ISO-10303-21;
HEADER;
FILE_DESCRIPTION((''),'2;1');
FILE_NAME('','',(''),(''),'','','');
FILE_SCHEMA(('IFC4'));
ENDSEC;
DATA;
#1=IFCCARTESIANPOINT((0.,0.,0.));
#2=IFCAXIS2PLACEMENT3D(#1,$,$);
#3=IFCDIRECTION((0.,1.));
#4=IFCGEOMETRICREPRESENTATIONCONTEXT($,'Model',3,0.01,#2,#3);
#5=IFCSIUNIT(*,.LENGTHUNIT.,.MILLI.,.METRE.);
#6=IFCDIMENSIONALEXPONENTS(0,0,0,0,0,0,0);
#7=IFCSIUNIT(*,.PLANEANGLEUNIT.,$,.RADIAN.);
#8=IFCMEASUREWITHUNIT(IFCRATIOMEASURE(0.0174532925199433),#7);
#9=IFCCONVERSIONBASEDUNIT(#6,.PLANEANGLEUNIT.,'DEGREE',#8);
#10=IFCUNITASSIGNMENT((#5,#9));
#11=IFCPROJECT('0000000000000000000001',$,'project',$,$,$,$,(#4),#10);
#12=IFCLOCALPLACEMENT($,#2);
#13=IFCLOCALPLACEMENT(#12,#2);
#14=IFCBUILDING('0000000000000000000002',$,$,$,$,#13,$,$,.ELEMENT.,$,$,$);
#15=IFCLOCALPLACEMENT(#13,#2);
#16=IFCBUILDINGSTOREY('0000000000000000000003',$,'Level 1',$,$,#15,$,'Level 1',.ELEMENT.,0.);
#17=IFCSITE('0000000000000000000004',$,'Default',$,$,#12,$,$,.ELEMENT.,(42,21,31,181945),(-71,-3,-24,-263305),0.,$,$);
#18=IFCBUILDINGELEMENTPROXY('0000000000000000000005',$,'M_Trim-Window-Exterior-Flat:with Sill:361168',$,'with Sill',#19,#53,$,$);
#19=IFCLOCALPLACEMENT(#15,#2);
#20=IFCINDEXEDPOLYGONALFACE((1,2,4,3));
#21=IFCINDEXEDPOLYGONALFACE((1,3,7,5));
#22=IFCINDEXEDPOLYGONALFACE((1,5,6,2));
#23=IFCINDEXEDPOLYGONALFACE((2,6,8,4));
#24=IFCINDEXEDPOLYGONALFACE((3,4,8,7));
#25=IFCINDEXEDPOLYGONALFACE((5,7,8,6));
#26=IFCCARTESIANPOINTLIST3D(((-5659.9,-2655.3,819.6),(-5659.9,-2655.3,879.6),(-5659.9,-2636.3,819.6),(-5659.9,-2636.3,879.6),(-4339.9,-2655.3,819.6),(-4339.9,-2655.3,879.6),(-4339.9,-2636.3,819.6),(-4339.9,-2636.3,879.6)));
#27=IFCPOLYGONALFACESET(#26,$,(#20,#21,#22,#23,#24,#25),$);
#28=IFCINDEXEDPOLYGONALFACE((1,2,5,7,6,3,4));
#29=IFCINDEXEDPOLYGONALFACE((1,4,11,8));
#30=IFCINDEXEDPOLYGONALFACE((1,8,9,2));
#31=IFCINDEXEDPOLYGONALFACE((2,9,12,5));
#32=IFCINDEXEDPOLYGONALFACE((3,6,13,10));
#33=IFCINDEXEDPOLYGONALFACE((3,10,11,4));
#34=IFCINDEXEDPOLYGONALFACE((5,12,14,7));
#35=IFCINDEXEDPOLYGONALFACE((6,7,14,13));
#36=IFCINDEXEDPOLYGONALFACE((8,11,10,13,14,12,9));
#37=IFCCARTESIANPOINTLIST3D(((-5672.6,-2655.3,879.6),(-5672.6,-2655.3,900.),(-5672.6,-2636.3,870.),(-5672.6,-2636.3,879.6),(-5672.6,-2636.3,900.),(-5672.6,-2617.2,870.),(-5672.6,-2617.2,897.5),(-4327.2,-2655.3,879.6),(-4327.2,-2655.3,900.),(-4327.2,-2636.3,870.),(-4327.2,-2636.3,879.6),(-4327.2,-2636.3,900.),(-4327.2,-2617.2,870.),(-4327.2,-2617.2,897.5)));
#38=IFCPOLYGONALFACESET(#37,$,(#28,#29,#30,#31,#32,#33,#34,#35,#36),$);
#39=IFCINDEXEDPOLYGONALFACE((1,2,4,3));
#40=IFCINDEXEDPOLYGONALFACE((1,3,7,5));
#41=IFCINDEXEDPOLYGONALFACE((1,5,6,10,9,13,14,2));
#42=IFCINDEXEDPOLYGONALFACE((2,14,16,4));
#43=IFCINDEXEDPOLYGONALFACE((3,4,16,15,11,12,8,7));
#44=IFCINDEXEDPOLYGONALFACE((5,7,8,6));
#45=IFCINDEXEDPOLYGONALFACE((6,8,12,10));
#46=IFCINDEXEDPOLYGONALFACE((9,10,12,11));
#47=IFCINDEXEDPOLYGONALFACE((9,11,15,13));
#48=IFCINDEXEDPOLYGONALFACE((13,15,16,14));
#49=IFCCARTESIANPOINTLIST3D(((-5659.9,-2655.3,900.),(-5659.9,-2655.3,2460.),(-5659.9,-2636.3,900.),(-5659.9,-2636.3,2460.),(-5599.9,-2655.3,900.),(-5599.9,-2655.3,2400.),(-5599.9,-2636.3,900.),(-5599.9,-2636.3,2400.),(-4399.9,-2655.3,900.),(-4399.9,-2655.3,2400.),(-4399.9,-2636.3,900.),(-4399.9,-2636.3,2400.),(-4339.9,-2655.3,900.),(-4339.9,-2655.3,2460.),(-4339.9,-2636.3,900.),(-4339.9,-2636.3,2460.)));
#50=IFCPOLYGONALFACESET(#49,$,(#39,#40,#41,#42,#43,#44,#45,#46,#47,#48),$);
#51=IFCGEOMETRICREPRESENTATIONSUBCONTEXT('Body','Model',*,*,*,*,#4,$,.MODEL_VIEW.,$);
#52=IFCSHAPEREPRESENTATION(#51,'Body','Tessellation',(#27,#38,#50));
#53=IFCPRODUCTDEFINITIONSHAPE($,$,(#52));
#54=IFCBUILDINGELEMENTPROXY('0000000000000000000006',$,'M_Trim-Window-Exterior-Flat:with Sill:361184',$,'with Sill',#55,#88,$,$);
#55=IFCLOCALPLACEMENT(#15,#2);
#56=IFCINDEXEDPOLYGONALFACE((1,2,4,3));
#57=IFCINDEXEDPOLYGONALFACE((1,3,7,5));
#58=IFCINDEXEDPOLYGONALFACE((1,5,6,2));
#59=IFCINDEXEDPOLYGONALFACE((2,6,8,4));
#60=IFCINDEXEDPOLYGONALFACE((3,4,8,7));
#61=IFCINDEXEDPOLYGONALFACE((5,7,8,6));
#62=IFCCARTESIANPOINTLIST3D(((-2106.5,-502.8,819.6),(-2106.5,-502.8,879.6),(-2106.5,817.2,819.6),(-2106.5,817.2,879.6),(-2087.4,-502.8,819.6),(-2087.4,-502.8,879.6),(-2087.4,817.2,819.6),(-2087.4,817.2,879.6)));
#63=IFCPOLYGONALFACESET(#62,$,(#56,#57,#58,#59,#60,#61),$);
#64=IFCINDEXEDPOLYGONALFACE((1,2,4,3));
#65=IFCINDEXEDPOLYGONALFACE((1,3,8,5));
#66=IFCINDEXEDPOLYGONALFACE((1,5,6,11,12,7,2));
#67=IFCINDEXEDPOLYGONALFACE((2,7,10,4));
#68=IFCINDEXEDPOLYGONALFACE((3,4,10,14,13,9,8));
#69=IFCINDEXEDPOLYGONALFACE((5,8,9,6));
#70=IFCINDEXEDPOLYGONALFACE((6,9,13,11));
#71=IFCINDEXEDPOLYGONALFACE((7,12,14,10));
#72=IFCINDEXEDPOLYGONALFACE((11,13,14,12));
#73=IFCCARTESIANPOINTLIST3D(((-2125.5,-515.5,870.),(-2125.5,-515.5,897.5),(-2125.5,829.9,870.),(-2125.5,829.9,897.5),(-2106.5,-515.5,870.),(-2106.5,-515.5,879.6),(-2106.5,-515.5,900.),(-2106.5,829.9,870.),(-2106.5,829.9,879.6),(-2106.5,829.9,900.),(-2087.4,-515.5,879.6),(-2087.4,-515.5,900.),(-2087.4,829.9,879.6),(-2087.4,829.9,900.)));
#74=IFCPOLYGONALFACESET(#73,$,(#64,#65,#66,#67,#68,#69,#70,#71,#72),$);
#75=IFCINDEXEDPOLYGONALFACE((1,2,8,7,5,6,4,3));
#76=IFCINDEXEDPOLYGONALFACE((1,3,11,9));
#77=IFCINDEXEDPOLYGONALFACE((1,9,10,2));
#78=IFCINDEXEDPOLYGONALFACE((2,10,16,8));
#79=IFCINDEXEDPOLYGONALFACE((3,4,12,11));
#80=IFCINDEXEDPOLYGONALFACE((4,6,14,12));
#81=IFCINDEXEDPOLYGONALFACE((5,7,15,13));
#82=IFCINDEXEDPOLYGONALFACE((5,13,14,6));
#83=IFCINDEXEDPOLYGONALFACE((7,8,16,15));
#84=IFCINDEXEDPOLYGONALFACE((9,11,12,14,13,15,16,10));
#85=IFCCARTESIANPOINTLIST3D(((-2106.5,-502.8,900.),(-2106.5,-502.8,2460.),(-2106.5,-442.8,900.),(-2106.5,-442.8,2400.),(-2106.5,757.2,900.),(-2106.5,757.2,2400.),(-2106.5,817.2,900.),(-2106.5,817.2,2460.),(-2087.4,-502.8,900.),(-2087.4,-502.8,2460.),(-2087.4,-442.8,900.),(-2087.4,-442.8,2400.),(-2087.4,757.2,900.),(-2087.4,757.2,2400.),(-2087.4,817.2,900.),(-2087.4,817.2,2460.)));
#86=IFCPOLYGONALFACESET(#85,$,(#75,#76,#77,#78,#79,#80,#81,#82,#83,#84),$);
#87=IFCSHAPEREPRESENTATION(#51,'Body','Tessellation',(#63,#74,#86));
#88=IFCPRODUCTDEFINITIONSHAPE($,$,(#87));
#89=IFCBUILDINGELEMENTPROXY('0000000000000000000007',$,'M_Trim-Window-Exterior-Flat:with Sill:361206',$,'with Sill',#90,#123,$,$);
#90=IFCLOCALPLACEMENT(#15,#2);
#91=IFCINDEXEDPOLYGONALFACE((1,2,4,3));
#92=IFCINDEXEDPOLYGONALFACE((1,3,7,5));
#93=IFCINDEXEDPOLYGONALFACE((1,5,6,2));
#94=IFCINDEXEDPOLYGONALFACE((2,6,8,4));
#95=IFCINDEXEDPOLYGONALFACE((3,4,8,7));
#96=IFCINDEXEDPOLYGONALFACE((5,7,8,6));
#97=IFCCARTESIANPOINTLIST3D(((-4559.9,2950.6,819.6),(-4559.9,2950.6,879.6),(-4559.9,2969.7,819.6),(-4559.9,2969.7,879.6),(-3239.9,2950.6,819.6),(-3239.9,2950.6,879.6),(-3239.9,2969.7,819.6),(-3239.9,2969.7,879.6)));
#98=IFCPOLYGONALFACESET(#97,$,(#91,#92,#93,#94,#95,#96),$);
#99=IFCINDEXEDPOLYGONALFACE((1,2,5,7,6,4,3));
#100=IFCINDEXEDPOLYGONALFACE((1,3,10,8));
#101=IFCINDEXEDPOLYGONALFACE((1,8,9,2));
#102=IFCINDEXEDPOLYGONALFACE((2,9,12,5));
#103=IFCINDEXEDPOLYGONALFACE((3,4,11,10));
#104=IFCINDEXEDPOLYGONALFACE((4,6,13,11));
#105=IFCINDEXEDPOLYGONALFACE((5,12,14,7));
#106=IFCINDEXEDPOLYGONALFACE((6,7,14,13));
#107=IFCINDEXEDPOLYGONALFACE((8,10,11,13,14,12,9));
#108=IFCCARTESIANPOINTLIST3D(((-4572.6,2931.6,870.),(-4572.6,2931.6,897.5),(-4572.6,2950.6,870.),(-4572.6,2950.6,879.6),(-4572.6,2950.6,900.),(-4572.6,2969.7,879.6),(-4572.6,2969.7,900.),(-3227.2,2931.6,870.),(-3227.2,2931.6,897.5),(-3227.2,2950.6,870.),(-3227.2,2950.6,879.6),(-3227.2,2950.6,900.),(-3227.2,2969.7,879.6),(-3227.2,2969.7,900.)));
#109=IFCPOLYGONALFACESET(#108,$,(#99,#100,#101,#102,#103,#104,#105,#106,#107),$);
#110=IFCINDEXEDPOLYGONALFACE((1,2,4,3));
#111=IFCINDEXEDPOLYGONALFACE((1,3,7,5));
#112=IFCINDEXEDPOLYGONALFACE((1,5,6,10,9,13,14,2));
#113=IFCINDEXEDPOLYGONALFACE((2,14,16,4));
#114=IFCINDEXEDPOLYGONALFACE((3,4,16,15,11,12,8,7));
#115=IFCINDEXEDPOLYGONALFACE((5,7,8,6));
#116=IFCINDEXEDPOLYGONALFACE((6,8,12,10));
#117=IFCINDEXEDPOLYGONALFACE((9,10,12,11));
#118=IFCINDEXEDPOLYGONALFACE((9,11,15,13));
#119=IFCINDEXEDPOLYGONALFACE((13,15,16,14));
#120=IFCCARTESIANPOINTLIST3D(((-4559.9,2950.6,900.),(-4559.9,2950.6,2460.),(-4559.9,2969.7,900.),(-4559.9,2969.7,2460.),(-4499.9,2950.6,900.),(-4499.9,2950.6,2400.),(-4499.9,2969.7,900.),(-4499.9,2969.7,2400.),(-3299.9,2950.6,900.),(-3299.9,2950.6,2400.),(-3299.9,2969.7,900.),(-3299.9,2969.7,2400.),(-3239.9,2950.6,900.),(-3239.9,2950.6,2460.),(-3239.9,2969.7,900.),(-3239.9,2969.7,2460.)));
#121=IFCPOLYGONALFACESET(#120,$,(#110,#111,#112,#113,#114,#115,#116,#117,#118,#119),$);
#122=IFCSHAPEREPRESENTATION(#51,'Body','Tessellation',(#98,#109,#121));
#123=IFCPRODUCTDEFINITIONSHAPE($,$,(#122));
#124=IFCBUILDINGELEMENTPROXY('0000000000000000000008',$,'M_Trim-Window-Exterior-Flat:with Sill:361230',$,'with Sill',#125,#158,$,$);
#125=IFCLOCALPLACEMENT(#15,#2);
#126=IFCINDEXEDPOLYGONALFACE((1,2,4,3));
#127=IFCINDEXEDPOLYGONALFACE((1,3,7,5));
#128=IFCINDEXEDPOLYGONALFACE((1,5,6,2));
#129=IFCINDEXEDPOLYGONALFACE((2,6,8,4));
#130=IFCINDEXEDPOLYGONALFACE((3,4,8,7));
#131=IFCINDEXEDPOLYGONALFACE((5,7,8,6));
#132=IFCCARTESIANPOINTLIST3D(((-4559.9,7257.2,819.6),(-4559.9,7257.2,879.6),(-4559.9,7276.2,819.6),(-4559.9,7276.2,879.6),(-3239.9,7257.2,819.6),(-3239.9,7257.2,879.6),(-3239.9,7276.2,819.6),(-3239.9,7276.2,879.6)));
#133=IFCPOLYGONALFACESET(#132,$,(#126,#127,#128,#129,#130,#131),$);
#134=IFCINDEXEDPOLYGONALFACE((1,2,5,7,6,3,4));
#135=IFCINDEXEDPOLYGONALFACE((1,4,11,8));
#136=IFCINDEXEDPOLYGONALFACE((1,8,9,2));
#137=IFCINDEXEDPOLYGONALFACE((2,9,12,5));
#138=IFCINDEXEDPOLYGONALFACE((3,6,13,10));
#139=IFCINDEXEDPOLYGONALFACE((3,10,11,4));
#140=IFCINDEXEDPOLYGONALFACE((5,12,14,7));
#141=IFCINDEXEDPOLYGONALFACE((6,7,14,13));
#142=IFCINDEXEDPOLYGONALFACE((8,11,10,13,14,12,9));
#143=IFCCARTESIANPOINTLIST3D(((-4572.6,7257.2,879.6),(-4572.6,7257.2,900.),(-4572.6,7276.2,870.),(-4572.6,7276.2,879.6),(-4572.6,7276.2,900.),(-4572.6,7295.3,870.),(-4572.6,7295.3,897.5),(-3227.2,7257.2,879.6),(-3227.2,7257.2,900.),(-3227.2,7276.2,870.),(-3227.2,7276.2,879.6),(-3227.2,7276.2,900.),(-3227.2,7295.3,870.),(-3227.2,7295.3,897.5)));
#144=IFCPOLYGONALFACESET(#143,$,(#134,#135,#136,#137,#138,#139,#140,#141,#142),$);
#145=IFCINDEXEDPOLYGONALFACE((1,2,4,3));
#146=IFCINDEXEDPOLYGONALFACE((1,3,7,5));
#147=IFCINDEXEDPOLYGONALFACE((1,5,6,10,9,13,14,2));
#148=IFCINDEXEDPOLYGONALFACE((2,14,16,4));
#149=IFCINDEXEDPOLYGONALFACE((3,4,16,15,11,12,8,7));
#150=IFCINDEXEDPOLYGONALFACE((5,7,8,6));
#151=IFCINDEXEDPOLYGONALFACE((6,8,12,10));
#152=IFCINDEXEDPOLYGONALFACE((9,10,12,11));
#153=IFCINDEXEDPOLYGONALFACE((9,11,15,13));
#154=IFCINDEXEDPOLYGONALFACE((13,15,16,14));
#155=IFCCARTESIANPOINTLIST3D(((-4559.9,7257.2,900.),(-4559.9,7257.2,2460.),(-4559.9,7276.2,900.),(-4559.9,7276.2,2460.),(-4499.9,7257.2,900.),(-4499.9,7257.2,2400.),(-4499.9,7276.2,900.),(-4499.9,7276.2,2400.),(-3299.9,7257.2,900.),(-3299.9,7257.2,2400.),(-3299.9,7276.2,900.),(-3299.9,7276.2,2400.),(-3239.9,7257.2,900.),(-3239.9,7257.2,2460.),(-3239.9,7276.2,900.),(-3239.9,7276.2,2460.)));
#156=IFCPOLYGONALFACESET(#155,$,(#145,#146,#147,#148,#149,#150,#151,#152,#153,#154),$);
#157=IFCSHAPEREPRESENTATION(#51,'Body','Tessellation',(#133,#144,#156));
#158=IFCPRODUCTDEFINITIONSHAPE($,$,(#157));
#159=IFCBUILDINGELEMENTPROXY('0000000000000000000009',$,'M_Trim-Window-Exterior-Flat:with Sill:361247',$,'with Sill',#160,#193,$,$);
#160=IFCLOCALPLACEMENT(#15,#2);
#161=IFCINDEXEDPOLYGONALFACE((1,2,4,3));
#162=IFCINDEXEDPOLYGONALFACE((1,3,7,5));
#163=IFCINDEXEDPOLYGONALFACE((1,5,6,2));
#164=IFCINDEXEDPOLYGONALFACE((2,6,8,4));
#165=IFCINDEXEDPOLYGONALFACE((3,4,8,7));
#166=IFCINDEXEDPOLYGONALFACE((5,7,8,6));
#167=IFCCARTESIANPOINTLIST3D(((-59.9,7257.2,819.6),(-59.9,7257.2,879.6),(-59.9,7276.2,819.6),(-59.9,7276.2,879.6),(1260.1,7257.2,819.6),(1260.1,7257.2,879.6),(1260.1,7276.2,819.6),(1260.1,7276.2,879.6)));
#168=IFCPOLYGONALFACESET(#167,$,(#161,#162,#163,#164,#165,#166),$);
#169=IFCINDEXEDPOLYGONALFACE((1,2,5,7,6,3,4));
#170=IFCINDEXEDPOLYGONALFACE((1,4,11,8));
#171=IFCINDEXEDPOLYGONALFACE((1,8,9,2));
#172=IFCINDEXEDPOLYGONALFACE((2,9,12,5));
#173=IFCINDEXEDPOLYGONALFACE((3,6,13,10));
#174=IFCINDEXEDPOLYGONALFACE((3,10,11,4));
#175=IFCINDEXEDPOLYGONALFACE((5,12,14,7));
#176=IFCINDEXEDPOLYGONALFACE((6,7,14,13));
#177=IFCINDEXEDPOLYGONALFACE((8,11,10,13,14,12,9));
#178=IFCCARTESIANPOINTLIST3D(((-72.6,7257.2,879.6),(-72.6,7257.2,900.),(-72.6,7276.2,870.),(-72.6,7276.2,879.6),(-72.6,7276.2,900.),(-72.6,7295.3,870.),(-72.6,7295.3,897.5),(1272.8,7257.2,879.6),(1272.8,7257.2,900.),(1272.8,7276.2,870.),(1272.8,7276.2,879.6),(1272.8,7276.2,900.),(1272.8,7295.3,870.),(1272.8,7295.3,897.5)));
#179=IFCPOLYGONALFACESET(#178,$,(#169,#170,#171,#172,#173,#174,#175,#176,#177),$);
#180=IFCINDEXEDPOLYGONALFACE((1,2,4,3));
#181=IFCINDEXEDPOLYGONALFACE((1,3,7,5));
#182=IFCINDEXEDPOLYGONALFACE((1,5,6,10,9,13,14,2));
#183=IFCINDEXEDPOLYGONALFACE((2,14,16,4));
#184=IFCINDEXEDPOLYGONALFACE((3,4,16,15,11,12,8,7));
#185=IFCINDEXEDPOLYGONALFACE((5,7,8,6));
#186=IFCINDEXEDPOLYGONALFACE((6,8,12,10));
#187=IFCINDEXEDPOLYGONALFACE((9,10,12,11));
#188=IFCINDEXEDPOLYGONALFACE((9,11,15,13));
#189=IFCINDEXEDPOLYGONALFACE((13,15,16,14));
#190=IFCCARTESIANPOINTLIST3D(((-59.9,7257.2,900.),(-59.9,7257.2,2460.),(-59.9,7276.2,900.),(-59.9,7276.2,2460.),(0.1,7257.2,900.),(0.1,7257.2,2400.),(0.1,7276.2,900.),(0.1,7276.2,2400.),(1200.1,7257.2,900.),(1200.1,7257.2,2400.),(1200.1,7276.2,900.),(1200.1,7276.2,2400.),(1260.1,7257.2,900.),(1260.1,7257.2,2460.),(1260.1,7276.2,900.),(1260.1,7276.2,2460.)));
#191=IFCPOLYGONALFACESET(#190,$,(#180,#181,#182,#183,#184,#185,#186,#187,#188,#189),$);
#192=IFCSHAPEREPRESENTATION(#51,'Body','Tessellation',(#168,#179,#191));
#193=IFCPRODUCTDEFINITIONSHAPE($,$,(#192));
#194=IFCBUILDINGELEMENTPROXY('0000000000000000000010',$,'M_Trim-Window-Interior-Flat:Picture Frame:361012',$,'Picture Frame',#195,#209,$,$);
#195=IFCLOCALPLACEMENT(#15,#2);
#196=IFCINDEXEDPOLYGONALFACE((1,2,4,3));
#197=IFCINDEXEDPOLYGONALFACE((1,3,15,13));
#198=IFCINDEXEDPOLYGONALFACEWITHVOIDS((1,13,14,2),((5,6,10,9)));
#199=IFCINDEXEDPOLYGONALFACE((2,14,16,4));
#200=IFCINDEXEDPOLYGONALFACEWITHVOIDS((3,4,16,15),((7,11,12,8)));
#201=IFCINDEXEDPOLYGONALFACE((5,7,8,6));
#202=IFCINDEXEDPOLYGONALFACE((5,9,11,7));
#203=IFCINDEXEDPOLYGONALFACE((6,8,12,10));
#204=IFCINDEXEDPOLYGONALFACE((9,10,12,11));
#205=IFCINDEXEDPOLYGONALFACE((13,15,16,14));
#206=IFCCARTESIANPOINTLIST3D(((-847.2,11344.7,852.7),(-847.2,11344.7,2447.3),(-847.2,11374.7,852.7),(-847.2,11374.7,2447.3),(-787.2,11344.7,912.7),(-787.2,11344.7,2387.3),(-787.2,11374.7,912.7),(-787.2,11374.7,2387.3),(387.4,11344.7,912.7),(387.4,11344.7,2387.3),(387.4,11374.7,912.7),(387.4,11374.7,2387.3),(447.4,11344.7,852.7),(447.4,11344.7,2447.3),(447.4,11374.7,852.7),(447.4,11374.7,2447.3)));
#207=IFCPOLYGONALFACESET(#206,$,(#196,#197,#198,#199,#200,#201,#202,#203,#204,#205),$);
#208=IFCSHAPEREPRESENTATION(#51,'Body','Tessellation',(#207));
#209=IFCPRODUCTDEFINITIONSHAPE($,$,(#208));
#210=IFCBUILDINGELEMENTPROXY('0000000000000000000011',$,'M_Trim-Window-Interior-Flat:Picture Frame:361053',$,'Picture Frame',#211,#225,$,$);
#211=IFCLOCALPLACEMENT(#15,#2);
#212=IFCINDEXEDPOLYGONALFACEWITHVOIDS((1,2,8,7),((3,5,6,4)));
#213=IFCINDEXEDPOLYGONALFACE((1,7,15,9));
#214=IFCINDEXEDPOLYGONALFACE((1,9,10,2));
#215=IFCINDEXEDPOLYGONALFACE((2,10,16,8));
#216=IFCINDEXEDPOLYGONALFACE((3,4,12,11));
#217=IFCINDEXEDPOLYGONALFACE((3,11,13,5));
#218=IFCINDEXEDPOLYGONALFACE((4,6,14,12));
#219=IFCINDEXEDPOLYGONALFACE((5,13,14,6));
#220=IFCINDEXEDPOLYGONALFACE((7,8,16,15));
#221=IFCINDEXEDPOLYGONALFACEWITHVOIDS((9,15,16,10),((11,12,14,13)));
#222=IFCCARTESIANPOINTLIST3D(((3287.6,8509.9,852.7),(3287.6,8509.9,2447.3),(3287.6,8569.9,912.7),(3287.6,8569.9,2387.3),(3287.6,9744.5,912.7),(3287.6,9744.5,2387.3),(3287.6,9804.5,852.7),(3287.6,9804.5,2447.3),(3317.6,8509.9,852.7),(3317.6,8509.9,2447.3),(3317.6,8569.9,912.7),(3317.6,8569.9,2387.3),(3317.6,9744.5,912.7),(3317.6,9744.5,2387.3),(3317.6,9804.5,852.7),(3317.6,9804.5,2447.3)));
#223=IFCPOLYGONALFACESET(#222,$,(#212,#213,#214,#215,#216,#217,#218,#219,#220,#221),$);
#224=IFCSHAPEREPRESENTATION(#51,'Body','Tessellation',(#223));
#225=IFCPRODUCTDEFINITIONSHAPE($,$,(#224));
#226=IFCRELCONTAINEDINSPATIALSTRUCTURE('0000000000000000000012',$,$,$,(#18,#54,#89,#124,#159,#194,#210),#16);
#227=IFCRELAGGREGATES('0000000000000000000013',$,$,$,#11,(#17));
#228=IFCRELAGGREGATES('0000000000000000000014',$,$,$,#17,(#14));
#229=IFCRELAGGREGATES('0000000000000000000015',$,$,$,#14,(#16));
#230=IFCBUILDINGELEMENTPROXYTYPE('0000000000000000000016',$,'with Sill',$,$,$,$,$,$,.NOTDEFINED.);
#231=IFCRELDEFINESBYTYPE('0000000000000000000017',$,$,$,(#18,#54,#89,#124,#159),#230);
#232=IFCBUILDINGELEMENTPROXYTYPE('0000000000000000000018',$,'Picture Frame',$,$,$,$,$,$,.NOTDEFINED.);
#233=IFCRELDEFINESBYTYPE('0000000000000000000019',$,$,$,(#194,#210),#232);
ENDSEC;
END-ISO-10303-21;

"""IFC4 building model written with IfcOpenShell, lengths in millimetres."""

from ifc_helpers import new_model, entity, si_unit, converted_unit, direction, frame, frame_2d, origin, place, context, subcontext, project, spatial, polyline, rectangle, outline, extrude, source, transform, mapped, type_object, type_shapes, element, save


model = new_model("IFC4")

# Units and contexts
model_context = context("Model", 3, precision=0.01, world=origin(), true_north=direction((0.0, 1.0)))
body_context = subcontext(model_context, "Body", "Model", "MODEL_VIEW")
ifc_project = project(units=[si_unit("LENGTHUNIT", "METRE", prefix="MILLI"), converted_unit("PLANEANGLEUNIT", "DEGREE", entity("IfcRatioMeasure", 0.0174532925199433), si_unit("PLANEANGLEUNIT", "RADIAN"), dimensions=[0, 0, 0, 0, 0, 0, 0])], contexts=[model_context])

# Site, building, storey
site_placement = place(None, origin())
site = spatial("IfcSite", under=ifc_project, at=site_placement, Name="Default", CompositionType="ELEMENT", RefLatitude=(42, 21, 31, 181945), RefLongitude=(-71, -3, -24, -263305), RefElevation=0.0)
building_placement = place(site_placement, origin())
building = spatial("IfcBuilding", under=site, at=building_placement, CompositionType="ELEMENT")
storey_placement = place(building_placement, origin())
storey = spatial("IfcBuildingStorey", under=building, at=storey_placement, Name="Level 1", LongName="Level 1", CompositionType="ELEMENT", Elevation=0.0)

# Building element proxies
building_element_proxy_type_1 = type_object("IfcBuildingElementProxyType", Name="with Sill", PredefinedType="NOTDEFINED")
shared_shape_1 = source(origin(), body_context, "Body", "SweptSolid", [
    extrude(rectangle(XDim=1320.0, YDim=60.0, at=frame_2d((0.0, 0.0), x_axis=(1.0, 0.0))), frame((0.0, -1550.4, 0.0), z_axis=(0.0, 0.0, 1.0), x_axis=(-1.0, 0.0, 0.0)), (0.0, 0.0, 1.0), 19.1),
    extrude(outline(polyline([(-19.0, -15.2), (0.0, -15.2), (0.0, -5.7), (19.0, -5.7), (19.0, 14.8), (0.0, 14.8), (-19.0, 12.3), (-19.0, -15.2)])), frame((-672.7, -1514.8, 19.0), z_axis=(1.0, 0.0, 0.0), x_axis=(0.0, 0.0, -1.0)), (0.0, 0.0, 1.0), 1345.4),
    extrude(outline(polyline([(-795.0, -660.0), (765.0, -660.0), (765.0, -600.0), (-735.0, -600.0), (-735.0, 600.0), (765.0, 600.0), (765.0, 660.0), (-795.0, 660.0), (-795.0, -660.0)])), frame((0.0, -735.0, 0.0), z_axis=(0.0, 0.0, 1.0), x_axis=(0.0, -1.0, 0.0)), (0.0, 0.0, 1.0), 19.1),
])
type_shapes(building_element_proxy_type_1, [shared_shape_1])
for number, where, z_axis, x_axis, name in (
    (1, (-4999.9, -2655.3, 2400.0), (0.0, 1.0, 0.0), (-1.0, 0.0, 0.0), "M_Trim-Window-Exterior-Flat:with Sill:361168"),
    (2, (-2087.4, 157.2, 2400.0), (-1.0, 0.0, 0.0), (0.0, -1.0, 0.0), "M_Trim-Window-Exterior-Flat:with Sill:361184"),
    (3, (-3899.9, 2969.7, 2400.0), (0.0, -1.0, 0.0), (1.0, 0.0, 0.0), "M_Trim-Window-Exterior-Flat:with Sill:361206"),
    (4, (-3899.9, 7257.2, 2400.0), (0.0, 1.0, 0.0), (-1.0, 0.0, 0.0), "M_Trim-Window-Exterior-Flat:with Sill:361230"),
    (5, (600.1, 7257.2, 2400.0), (0.0, 1.0, 0.0), (-1.0, 0.0, 0.0), "M_Trim-Window-Exterior-Flat:with Sill:361247"),
):
    element("IfcBuildingElementProxy", number, at=place(storey_placement, frame(where, z_axis=z_axis, x_axis=x_axis)), inside=storey, type_object=building_element_proxy_type_1, Name=name, ObjectType="with Sill", context=body_context, shape_type="MappedRepresentation", body=[
        mapped(shared_shape_1, transform((0.0, 0.0, 0.0), scale=1.0)),
    ])
building_element_proxy_type_2 = type_object("IfcBuildingElementProxyType", Name="Picture Frame", PredefinedType="NOTDEFINED")
shared_shape_2 = source(origin(), body_context, "Body", "SweptSolid", [
    extrude(outline(polyline([(-647.3, -797.3), (647.3, -797.3), (647.3, 797.3), (-647.3, 797.3), (-647.3, -797.3)]), holes=[polyline([(-587.3, -737.3), (-587.3, 737.3), (587.3, 737.3), (587.3, -737.3), (-587.3, -737.3)])]), frame((0.0, -750.0, 0.0), z_axis=(0.0, 0.0, 1.0), x_axis=(-1.0, 0.0, 0.0)), (0.0, 0.0, 1.0), 30.0),
])
type_shapes(building_element_proxy_type_2, [shared_shape_2])
for number, where, z_axis, x_axis, name in (
    (6, (-199.9, 11344.7, 2400.0), (0.0, 1.0, 0.0), (-1.0, 0.0, 0.0), "M_Trim-Window-Interior-Flat:Picture Frame:361012"),
    (7, (3287.6, 9157.2, 2400.0), (1.0, 0.0, 0.0), (0.0, 1.0, 0.0), "M_Trim-Window-Interior-Flat:Picture Frame:361053"),
):
    element("IfcBuildingElementProxy", number, at=place(storey_placement, frame(where, z_axis=z_axis, x_axis=x_axis)), inside=storey, type_object=building_element_proxy_type_2, Name=name, ObjectType="Picture Frame", context=body_context, shape_type="MappedRepresentation", body=[
        mapped(shared_shape_2, transform((0.0, 0.0, 0.0), scale=1.0)),
    ])

save(model, "model.ifc")
